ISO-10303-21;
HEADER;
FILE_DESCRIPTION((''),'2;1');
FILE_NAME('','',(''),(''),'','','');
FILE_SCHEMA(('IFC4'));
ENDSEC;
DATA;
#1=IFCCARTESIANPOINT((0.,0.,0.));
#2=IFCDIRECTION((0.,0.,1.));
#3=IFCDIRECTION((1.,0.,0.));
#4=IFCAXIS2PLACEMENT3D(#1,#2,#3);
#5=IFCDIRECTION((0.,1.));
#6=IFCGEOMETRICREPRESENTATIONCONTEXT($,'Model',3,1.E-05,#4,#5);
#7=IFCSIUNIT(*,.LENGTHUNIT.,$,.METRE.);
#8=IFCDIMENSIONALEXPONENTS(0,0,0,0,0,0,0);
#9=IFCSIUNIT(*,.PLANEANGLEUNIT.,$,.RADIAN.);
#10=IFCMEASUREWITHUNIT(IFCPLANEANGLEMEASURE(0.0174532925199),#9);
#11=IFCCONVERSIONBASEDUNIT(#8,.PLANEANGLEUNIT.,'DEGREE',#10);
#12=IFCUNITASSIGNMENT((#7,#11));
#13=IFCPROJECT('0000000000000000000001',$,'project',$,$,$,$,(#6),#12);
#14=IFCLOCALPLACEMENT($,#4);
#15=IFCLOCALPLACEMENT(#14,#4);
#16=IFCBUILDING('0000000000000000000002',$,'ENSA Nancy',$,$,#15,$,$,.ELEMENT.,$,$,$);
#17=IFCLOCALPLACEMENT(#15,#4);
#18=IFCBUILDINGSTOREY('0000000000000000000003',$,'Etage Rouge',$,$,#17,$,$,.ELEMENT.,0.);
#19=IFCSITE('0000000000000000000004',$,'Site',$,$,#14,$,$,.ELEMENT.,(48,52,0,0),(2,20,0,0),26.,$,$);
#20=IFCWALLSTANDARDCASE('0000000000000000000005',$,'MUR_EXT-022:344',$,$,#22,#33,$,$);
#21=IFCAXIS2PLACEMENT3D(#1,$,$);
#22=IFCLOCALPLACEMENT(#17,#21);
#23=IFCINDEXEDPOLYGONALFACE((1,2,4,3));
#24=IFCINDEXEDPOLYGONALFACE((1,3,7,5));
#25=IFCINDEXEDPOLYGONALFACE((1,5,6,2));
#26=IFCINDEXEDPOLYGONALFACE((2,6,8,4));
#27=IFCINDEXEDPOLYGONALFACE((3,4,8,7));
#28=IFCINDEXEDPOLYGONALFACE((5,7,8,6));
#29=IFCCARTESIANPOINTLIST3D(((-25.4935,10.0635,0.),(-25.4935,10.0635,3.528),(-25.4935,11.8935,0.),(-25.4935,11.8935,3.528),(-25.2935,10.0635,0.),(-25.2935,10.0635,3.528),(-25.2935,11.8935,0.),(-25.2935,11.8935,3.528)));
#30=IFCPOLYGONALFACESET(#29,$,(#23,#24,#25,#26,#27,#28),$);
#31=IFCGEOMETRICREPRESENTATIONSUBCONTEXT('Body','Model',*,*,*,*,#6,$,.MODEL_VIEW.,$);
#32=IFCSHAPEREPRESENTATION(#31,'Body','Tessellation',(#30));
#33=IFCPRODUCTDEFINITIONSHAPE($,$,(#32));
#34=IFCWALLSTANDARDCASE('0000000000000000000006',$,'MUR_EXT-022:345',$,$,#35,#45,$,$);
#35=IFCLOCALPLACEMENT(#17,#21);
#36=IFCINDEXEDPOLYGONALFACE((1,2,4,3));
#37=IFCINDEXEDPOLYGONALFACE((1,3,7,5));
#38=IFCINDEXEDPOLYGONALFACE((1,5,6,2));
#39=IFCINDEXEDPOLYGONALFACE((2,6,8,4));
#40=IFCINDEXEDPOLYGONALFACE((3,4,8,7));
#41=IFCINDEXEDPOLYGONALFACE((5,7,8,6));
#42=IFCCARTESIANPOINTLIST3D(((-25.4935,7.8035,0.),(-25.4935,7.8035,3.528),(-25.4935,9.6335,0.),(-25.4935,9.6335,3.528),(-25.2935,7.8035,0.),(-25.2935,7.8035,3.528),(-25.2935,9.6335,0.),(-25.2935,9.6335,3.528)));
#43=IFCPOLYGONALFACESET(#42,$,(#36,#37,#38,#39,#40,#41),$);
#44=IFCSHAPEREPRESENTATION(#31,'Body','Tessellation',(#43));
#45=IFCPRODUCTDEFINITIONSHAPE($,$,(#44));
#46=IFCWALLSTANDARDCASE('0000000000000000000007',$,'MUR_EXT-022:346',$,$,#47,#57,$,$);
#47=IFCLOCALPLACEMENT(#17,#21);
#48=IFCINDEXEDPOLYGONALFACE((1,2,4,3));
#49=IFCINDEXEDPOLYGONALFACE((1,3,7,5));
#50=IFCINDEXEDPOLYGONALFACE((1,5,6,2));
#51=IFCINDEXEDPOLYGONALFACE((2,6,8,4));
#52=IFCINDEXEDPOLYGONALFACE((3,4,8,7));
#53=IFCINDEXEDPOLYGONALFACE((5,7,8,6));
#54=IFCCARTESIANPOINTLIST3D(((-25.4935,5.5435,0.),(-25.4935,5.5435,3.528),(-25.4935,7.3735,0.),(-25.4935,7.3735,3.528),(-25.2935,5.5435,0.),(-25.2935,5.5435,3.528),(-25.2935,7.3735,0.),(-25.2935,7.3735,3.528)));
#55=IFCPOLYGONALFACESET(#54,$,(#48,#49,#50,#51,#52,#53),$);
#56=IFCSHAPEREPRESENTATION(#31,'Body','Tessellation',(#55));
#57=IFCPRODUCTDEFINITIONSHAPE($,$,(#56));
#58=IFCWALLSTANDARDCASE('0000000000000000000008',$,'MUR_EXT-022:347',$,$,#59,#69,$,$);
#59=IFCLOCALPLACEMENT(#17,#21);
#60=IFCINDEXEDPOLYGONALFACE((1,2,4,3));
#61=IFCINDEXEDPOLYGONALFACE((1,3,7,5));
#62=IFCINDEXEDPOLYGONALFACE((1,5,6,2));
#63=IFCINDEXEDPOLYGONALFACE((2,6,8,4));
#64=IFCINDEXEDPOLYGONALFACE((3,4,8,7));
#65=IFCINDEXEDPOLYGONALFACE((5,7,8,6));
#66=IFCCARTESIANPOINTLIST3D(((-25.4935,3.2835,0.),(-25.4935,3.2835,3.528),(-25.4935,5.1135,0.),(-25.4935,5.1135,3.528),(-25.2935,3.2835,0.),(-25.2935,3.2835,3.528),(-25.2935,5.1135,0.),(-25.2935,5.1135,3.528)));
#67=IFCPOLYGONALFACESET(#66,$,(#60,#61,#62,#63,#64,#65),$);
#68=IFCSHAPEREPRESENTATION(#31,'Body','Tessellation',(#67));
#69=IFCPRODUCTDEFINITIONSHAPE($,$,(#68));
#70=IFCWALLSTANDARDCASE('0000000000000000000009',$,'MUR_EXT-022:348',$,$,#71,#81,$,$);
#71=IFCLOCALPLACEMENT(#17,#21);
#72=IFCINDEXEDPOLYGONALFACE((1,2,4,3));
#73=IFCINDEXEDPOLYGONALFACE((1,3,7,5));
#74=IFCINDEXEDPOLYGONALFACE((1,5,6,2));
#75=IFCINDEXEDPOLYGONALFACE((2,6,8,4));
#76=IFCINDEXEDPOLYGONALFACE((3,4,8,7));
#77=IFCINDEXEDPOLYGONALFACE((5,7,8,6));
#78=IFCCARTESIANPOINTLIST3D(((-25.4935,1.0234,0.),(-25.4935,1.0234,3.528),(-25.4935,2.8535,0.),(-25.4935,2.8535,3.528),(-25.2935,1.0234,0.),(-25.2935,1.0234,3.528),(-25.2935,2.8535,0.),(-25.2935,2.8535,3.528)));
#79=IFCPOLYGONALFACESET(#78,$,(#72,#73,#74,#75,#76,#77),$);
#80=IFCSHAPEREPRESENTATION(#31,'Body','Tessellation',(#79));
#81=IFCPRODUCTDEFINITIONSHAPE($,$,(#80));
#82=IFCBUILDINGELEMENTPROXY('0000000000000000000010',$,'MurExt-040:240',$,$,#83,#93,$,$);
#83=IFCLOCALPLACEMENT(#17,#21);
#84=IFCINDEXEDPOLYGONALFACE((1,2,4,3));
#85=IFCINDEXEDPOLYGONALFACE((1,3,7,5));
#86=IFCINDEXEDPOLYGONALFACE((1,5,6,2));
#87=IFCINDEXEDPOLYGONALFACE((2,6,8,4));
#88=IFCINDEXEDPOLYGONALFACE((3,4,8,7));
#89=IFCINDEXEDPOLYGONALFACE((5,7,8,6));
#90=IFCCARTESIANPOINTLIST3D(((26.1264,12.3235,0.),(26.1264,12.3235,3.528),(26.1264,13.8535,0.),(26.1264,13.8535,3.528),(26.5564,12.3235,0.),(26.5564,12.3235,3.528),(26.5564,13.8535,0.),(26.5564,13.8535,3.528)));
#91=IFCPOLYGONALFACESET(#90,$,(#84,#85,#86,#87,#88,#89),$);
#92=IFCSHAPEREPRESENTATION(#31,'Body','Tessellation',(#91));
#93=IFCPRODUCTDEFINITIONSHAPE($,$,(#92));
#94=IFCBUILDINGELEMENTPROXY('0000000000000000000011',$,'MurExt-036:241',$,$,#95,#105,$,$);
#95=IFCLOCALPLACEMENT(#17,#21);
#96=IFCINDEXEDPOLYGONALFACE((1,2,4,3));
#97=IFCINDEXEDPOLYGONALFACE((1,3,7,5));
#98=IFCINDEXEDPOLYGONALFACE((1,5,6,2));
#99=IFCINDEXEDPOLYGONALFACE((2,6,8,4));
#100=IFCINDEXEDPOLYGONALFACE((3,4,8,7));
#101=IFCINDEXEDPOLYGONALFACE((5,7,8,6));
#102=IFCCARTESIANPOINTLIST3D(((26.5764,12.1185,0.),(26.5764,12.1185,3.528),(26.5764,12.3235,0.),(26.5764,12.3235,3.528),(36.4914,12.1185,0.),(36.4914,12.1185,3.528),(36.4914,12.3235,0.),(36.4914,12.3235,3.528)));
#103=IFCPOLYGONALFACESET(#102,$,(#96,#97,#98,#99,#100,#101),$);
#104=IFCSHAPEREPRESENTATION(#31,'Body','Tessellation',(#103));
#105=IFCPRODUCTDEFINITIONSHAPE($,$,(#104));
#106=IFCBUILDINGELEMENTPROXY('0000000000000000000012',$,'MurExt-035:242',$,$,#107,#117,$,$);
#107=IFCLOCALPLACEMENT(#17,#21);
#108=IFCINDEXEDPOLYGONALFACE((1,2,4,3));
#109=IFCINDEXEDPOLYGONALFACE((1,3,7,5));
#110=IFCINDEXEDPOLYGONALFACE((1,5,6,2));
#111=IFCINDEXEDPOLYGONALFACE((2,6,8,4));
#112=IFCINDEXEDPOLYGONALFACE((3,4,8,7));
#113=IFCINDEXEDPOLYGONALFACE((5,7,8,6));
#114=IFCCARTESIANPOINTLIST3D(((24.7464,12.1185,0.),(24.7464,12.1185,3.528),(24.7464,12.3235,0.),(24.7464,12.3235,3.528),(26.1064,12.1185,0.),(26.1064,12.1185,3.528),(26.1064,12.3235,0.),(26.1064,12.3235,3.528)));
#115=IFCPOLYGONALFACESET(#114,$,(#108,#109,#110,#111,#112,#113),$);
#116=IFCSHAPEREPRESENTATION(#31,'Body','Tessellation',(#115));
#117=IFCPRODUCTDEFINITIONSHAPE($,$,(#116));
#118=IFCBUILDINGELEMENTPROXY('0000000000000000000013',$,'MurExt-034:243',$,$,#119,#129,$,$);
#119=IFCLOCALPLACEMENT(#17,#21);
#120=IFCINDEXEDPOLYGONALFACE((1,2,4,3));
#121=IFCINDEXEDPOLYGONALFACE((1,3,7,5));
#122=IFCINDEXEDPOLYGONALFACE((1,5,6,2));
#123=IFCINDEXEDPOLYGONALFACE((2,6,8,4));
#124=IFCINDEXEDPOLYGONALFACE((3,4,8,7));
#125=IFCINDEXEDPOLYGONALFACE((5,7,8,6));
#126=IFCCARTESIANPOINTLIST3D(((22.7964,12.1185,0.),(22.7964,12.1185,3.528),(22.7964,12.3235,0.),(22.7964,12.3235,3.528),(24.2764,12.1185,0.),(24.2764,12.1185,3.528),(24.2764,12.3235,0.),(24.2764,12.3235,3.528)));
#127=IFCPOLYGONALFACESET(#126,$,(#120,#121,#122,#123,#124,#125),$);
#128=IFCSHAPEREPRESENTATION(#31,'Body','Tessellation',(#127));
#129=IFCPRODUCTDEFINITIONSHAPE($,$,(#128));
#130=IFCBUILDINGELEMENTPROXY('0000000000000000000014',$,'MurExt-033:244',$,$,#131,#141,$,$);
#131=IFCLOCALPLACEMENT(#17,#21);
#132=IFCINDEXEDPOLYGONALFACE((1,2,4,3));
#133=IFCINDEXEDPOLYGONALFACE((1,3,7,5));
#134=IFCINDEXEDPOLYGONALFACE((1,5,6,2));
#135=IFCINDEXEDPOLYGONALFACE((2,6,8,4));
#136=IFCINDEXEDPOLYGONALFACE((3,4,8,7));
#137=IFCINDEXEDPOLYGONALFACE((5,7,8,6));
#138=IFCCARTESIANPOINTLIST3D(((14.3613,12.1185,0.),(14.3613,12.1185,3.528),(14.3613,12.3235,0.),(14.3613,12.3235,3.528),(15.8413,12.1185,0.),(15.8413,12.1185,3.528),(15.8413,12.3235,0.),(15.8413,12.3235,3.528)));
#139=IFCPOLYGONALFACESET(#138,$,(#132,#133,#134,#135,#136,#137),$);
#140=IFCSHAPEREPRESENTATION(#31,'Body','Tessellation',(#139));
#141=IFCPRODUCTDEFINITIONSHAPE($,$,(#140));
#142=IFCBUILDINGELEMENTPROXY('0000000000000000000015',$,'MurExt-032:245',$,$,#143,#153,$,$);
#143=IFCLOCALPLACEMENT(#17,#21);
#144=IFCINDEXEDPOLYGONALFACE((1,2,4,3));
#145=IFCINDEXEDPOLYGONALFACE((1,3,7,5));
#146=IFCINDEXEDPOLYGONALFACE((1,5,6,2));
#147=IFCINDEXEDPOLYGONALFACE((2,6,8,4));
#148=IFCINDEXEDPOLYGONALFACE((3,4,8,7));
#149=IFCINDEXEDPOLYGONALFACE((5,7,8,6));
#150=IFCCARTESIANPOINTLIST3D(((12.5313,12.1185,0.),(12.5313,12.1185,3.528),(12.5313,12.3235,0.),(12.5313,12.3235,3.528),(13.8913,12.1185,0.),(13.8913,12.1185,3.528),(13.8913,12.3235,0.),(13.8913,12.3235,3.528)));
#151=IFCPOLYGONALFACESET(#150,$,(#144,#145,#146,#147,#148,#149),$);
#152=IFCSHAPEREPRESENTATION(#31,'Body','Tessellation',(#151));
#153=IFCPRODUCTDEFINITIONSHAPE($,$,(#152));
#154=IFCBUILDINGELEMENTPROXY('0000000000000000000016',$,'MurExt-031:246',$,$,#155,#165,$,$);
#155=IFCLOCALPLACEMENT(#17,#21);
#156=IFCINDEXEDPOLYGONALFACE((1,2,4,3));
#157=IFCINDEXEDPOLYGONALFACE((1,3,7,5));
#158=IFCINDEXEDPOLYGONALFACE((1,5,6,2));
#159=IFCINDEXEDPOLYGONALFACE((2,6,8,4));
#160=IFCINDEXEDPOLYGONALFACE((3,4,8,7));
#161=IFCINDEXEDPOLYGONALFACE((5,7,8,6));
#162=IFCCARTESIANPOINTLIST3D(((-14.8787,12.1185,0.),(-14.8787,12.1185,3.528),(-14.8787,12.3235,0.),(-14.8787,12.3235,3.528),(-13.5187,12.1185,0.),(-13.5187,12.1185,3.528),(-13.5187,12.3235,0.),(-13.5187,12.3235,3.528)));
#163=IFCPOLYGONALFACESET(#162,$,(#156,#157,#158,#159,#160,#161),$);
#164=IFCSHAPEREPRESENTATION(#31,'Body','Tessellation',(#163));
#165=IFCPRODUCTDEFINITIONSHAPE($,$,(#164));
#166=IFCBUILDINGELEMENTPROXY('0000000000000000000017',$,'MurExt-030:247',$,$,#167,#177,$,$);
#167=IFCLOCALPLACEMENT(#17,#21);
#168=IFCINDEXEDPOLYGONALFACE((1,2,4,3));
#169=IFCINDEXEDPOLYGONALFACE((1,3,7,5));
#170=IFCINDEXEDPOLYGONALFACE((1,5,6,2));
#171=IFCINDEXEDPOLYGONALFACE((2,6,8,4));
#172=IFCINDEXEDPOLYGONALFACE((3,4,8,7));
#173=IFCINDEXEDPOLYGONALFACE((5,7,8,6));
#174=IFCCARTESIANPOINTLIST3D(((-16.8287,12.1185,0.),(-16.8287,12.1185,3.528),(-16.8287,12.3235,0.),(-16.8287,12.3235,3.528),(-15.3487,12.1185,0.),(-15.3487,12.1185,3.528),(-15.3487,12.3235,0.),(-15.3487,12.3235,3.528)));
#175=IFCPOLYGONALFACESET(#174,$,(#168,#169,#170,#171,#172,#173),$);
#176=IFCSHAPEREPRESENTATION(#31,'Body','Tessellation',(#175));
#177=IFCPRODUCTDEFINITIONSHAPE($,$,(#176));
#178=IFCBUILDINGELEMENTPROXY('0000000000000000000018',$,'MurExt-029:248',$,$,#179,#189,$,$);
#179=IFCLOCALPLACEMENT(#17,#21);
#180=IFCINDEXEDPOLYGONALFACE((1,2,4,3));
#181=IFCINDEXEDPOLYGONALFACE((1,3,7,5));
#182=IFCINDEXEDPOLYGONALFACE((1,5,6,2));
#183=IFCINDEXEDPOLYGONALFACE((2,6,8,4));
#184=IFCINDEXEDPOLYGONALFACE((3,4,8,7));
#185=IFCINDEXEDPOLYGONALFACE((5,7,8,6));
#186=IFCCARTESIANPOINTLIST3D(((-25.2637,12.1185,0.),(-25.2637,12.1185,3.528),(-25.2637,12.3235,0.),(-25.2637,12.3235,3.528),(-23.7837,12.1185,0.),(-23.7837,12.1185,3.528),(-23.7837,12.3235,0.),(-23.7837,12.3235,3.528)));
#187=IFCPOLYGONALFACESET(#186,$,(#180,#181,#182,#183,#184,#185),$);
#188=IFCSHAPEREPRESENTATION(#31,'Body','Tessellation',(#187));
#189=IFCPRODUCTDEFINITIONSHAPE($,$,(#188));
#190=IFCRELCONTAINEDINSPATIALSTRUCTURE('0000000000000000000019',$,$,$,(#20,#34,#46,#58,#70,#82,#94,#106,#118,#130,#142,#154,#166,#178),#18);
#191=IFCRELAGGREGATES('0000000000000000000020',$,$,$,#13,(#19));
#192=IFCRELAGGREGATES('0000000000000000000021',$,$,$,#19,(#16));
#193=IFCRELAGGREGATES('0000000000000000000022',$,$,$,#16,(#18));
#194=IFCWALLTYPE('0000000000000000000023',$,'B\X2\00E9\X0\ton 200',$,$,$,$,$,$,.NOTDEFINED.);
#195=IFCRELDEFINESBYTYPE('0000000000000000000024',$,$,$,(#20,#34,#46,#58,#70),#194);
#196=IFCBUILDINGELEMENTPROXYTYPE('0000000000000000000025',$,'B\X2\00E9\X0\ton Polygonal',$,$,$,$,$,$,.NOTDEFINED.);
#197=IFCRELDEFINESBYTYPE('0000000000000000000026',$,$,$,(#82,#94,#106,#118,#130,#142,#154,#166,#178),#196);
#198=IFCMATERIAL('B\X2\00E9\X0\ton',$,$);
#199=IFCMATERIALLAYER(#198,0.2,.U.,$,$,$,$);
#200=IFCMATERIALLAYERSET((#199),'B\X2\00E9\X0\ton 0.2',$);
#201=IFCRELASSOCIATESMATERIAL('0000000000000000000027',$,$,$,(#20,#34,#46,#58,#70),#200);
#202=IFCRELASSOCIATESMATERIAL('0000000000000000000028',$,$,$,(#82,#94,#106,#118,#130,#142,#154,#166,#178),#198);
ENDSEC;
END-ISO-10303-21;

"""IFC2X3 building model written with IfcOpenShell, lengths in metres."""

from ifc_helpers import new_model, entity, si_unit, converted_unit, direction, frame, origin_with_axes, place, context, subcontext, project, spatial, polyline, outline, extrude, material, layer, layer_set, layer_usage, type_object, element, save


model = new_model("IFC2X3")

# Units and contexts
model_context = context("Model", 3, precision=1e-05, world=origin_with_axes(), true_north=direction((0.0, 1.0)))
body_context = subcontext(model_context, "Body", "Model", "MODEL_VIEW")
ifc_project = project(units=[si_unit("LENGTHUNIT", "METRE"), converted_unit("PLANEANGLEUNIT", "DEGREE", entity("IfcPlaneAngleMeasure", 0.0174532925199), si_unit("PLANEANGLEUNIT", "RADIAN"), dimensions=[0, 0, 0, 0, 0, 0, 0])], contexts=[model_context])

# Site, building, storey
site_placement = place(None, origin_with_axes())
site = spatial("IfcSite", under=ifc_project, at=site_placement, Name="Site", CompositionType="ELEMENT", RefLatitude=(48, 52, 0, 0), RefLongitude=(2, 20, 0, 0), RefElevation=26.0)
building_placement = place(site_placement, origin_with_axes())
building = spatial("IfcBuilding", under=site, at=building_placement, Name="ENSA Nancy", CompositionType="ELEMENT")
storey_placement = place(building_placement, origin_with_axes())
storey = spatial("IfcBuildingStorey", under=building, at=storey_placement, Name="Etage Rouge", CompositionType="ELEMENT", Elevation=0.0)

# Walls
ifc_material = material(Name="Béton")
ifc_layer = layer(ifc_material, 0.2, ventilated="UNKNOWN")
ifc_layer_set = layer_set([ifc_layer], Name="Béton 0.2")
ifc_layer_usage_1 = layer_usage(ifc_layer_set, "AXIS2", "POSITIVE", -0.2)
wall_type = type_object("IfcWallType", Name="Béton 200", PredefinedType="NOTDEFINED")
wall_1_placement = place(storey_placement, frame((-25.2935, 11.8935, 0.0), z_axis=(0.0, 0.0, 1.0), x_axis=(0.0, -1.0, 0.0)))
element("IfcWallStandardCase", 1, at=wall_1_placement, inside=storey, type_object=wall_type, material=ifc_layer_usage_1, Name="MUR_EXT-022:344", context=body_context, shape_type="SweptSolid", body=[
    extrude(outline(polyline([(0.0, -0.2), (1.83, -0.2), (1.83, 0.0), (0.0, 0.0), (0.0, -0.2)])), origin_with_axes(), (0.0, 0.0, 1.0), 3.528),
])
ifc_layer_usage_2 = layer_usage(ifc_layer_set, "AXIS2", "POSITIVE", -0.2)
wall_2_placement = place(storey_placement, frame((-25.2935, 9.6335, 0.0), z_axis=(0.0, 0.0, 1.0), x_axis=(0.0, -1.0, 0.0)))
element("IfcWallStandardCase", 2, at=wall_2_placement, inside=storey, type_object=wall_type, material=ifc_layer_usage_2, Name="MUR_EXT-022:345", context=body_context, shape_type="SweptSolid", body=[
    extrude(outline(polyline([(0.0, -0.2), (1.83, -0.2), (1.83, 0.0), (0.0, 0.0), (0.0, -0.2)])), origin_with_axes(), (0.0, 0.0, 1.0), 3.528),
])
ifc_layer_usage_3 = layer_usage(ifc_layer_set, "AXIS2", "POSITIVE", -0.2)
wall_3_placement = place(storey_placement, frame((-25.2935, 7.3735, 0.0), z_axis=(0.0, 0.0, 1.0), x_axis=(0.0, -1.0, 0.0)))
element("IfcWallStandardCase", 3, at=wall_3_placement, inside=storey, type_object=wall_type, material=ifc_layer_usage_3, Name="MUR_EXT-022:346", context=body_context, shape_type="SweptSolid", body=[
    extrude(outline(polyline([(0.0, -0.2), (1.83, -0.2), (1.83, 0.0), (0.0, 0.0), (0.0, -0.2)])), origin_with_axes(), (0.0, 0.0, 1.0), 3.528),
])
ifc_layer_usage_4 = layer_usage(ifc_layer_set, "AXIS2", "POSITIVE", -0.2)
wall_4_placement = place(storey_placement, frame((-25.2935, 5.1135, 0.0), z_axis=(0.0, 0.0, 1.0), x_axis=(0.0, -1.0, 0.0)))
element("IfcWallStandardCase", 4, at=wall_4_placement, inside=storey, type_object=wall_type, material=ifc_layer_usage_4, Name="MUR_EXT-022:347", context=body_context, shape_type="SweptSolid", body=[
    extrude(outline(polyline([(0.0, -0.2), (1.83, -0.2), (1.83, 0.0), (0.0, 0.0), (0.0, -0.2)])), origin_with_axes(), (0.0, 0.0, 1.0), 3.528),
])
ifc_layer_usage_5 = layer_usage(ifc_layer_set, "AXIS2", "POSITIVE", -0.2)
wall_5_placement = place(storey_placement, frame((-25.2935, 2.8535, 0.0), z_axis=(0.0, 0.0, 1.0), x_axis=(0.0, -1.0, 0.0)))
element("IfcWallStandardCase", 5, at=wall_5_placement, inside=storey, type_object=wall_type, material=ifc_layer_usage_5, Name="MUR_EXT-022:348", context=body_context, shape_type="SweptSolid", body=[
    extrude(outline(polyline([(0.0, -0.2), (1.83, -0.2), (1.83, 0.0), (0.0, 0.0), (0.0, -0.2)])), origin_with_axes(), (0.0, 0.0, 1.0), 3.528),
])

# Building element proxies
building_element_proxy_type_1 = type_object("IfcBuildingElementProxyType", Name="Béton Polygonal", PredefinedType="NOTDEFINED")
proxy_1_placement = place(storey_placement, frame((26.1264, 13.8535, 0.0), z_axis=(0.0, 0.0, 1.0), x_axis=(0.0, -1.0, 0.0)))
element("IfcBuildingElementProxy", 6, at=proxy_1_placement, inside=storey, type_object=building_element_proxy_type_1, material=ifc_material, Name="MurExt-040:240", context=body_context, shape_type="SweptSolid", body=[
    extrude(outline(polyline([(0.0, 0.0), (1.53, 0.0), (1.53, 0.43), (0.0, 0.43), (0.0, 0.0)])), origin_with_axes(), (0.0, 0.0, 1.0), 3.528),
])
proxy_2_placement = place(storey_placement, frame((26.5764, 12.3235, 0.0), z_axis=(0.0, 0.0, 1.0), x_axis=(0.0, -1.0, 0.0)))
element("IfcBuildingElementProxy", 7, at=proxy_2_placement, inside=storey, type_object=building_element_proxy_type_1, material=ifc_material, Name="MurExt-036:241", context=body_context, shape_type="SweptSolid", body=[
    extrude(outline(polyline([(0.0, 0.0), (0.205, 0.0), (0.205, 9.915), (0.0, 9.915), (0.0, 0.0)])), origin_with_axes(), (0.0, 0.0, 1.0), 3.528),
])
proxy_3_placement = place(storey_placement, frame((24.7464, 12.3235, 0.0), z_axis=(0.0, 0.0, 1.0), x_axis=(0.0, -1.0, 0.0)))
element("IfcBuildingElementProxy", 8, at=proxy_3_placement, inside=storey, type_object=building_element_proxy_type_1, material=ifc_material, Name="MurExt-035:242", context=body_context, shape_type="SweptSolid", body=[
    extrude(outline(polyline([(0.0, 0.0), (0.205, 0.0), (0.205, 1.36), (0.0, 1.36), (0.0, 0.0)])), origin_with_axes(), (0.0, 0.0, 1.0), 3.528),
])
proxy_4_placement = place(storey_placement, frame((22.7964, 12.3235, 0.0), z_axis=(0.0, 0.0, 1.0), x_axis=(0.0, -1.0, 0.0)))
element("IfcBuildingElementProxy", 9, at=proxy_4_placement, inside=storey, type_object=building_element_proxy_type_1, material=ifc_material, Name="MurExt-034:243", context=body_context, shape_type="SweptSolid", body=[
    extrude(outline(polyline([(0.0, 0.0), (0.205, 0.0), (0.205, 1.48), (0.0, 1.48), (0.0, 0.0)])), origin_with_axes(), (0.0, 0.0, 1.0), 3.528),
])
proxy_5_placement = place(storey_placement, frame((14.3613, 12.3235, 0.0), z_axis=(0.0, 0.0, 1.0), x_axis=(0.000001, -1.0, 0.0)))
element("IfcBuildingElementProxy", 10, at=proxy_5_placement, inside=storey, type_object=building_element_proxy_type_1, material=ifc_material, Name="MurExt-033:244", context=body_context, shape_type="SweptSolid", body=[
    extrude(outline(polyline([(0.0, 0.0), (0.205, 0.0), (0.205, 1.48), (0.0, 1.48), (0.0, 0.0)])), origin_with_axes(), (0.0, 0.0, 1.0), 3.528),
])
proxy_6_placement = place(storey_placement, frame((12.5313, 12.3235, 0.0), z_axis=(0.0, 0.0, 1.0), x_axis=(0.0, -1.0, 0.0)))
element("IfcBuildingElementProxy", 11, at=proxy_6_placement, inside=storey, type_object=building_element_proxy_type_1, material=ifc_material, Name="MurExt-032:245", context=body_context, shape_type="SweptSolid", body=[
    extrude(outline(polyline([(0.0, 0.0), (0.205, 0.0), (0.205, 1.36), (0.0, 1.36), (0.0, 0.0)])), origin_with_axes(), (0.0, 0.0, 1.0), 3.528),
])
proxy_7_placement = place(storey_placement, frame((-14.8787, 12.3235, 0.0), z_axis=(0.0, 0.0, 1.0), x_axis=(0.0, -1.0, 0.0)))
element("IfcBuildingElementProxy", 12, at=proxy_7_placement, inside=storey, type_object=building_element_proxy_type_1, material=ifc_material, Name="MurExt-031:246", context=body_context, shape_type="SweptSolid", body=[
    extrude(outline(polyline([(0.0, 0.0), (0.205, 0.0), (0.205, 1.36), (0.0, 1.36), (0.0, 0.0)])), origin_with_axes(), (0.0, 0.0, 1.0), 3.528),
])
proxy_8_placement = place(storey_placement, frame((-16.8287, 12.3235, 0.0), z_axis=(0.0, 0.0, 1.0), x_axis=(-0.000001, -1.0, 0.0)))
element("IfcBuildingElementProxy", 13, at=proxy_8_placement, inside=storey, type_object=building_element_proxy_type_1, material=ifc_material, Name="MurExt-030:247", context=body_context, shape_type="SweptSolid", body=[
    extrude(outline(polyline([(0.0, 0.0), (0.205, 0.0), (0.205, 1.48), (0.0, 1.48), (0.0, 0.0)])), origin_with_axes(), (0.0, 0.0, 1.0), 3.528),
])
proxy_9_placement = place(storey_placement, frame((-25.2637, 12.3235, 0.0), z_axis=(0.0, 0.0, 1.0), x_axis=(0.0, -1.0, 0.0)))
element("IfcBuildingElementProxy", 14, at=proxy_9_placement, inside=storey, type_object=building_element_proxy_type_1, material=ifc_material, Name="MurExt-029:248", context=body_context, shape_type="SweptSolid", body=[
    extrude(outline(polyline([(0.0, 0.0), (0.205, 0.0), (0.205, 1.48), (0.0, 1.48), (0.0, 0.0)])), origin_with_axes(), (0.0, 0.0, 1.0), 3.528),
])

save(model, "model.ifc")
